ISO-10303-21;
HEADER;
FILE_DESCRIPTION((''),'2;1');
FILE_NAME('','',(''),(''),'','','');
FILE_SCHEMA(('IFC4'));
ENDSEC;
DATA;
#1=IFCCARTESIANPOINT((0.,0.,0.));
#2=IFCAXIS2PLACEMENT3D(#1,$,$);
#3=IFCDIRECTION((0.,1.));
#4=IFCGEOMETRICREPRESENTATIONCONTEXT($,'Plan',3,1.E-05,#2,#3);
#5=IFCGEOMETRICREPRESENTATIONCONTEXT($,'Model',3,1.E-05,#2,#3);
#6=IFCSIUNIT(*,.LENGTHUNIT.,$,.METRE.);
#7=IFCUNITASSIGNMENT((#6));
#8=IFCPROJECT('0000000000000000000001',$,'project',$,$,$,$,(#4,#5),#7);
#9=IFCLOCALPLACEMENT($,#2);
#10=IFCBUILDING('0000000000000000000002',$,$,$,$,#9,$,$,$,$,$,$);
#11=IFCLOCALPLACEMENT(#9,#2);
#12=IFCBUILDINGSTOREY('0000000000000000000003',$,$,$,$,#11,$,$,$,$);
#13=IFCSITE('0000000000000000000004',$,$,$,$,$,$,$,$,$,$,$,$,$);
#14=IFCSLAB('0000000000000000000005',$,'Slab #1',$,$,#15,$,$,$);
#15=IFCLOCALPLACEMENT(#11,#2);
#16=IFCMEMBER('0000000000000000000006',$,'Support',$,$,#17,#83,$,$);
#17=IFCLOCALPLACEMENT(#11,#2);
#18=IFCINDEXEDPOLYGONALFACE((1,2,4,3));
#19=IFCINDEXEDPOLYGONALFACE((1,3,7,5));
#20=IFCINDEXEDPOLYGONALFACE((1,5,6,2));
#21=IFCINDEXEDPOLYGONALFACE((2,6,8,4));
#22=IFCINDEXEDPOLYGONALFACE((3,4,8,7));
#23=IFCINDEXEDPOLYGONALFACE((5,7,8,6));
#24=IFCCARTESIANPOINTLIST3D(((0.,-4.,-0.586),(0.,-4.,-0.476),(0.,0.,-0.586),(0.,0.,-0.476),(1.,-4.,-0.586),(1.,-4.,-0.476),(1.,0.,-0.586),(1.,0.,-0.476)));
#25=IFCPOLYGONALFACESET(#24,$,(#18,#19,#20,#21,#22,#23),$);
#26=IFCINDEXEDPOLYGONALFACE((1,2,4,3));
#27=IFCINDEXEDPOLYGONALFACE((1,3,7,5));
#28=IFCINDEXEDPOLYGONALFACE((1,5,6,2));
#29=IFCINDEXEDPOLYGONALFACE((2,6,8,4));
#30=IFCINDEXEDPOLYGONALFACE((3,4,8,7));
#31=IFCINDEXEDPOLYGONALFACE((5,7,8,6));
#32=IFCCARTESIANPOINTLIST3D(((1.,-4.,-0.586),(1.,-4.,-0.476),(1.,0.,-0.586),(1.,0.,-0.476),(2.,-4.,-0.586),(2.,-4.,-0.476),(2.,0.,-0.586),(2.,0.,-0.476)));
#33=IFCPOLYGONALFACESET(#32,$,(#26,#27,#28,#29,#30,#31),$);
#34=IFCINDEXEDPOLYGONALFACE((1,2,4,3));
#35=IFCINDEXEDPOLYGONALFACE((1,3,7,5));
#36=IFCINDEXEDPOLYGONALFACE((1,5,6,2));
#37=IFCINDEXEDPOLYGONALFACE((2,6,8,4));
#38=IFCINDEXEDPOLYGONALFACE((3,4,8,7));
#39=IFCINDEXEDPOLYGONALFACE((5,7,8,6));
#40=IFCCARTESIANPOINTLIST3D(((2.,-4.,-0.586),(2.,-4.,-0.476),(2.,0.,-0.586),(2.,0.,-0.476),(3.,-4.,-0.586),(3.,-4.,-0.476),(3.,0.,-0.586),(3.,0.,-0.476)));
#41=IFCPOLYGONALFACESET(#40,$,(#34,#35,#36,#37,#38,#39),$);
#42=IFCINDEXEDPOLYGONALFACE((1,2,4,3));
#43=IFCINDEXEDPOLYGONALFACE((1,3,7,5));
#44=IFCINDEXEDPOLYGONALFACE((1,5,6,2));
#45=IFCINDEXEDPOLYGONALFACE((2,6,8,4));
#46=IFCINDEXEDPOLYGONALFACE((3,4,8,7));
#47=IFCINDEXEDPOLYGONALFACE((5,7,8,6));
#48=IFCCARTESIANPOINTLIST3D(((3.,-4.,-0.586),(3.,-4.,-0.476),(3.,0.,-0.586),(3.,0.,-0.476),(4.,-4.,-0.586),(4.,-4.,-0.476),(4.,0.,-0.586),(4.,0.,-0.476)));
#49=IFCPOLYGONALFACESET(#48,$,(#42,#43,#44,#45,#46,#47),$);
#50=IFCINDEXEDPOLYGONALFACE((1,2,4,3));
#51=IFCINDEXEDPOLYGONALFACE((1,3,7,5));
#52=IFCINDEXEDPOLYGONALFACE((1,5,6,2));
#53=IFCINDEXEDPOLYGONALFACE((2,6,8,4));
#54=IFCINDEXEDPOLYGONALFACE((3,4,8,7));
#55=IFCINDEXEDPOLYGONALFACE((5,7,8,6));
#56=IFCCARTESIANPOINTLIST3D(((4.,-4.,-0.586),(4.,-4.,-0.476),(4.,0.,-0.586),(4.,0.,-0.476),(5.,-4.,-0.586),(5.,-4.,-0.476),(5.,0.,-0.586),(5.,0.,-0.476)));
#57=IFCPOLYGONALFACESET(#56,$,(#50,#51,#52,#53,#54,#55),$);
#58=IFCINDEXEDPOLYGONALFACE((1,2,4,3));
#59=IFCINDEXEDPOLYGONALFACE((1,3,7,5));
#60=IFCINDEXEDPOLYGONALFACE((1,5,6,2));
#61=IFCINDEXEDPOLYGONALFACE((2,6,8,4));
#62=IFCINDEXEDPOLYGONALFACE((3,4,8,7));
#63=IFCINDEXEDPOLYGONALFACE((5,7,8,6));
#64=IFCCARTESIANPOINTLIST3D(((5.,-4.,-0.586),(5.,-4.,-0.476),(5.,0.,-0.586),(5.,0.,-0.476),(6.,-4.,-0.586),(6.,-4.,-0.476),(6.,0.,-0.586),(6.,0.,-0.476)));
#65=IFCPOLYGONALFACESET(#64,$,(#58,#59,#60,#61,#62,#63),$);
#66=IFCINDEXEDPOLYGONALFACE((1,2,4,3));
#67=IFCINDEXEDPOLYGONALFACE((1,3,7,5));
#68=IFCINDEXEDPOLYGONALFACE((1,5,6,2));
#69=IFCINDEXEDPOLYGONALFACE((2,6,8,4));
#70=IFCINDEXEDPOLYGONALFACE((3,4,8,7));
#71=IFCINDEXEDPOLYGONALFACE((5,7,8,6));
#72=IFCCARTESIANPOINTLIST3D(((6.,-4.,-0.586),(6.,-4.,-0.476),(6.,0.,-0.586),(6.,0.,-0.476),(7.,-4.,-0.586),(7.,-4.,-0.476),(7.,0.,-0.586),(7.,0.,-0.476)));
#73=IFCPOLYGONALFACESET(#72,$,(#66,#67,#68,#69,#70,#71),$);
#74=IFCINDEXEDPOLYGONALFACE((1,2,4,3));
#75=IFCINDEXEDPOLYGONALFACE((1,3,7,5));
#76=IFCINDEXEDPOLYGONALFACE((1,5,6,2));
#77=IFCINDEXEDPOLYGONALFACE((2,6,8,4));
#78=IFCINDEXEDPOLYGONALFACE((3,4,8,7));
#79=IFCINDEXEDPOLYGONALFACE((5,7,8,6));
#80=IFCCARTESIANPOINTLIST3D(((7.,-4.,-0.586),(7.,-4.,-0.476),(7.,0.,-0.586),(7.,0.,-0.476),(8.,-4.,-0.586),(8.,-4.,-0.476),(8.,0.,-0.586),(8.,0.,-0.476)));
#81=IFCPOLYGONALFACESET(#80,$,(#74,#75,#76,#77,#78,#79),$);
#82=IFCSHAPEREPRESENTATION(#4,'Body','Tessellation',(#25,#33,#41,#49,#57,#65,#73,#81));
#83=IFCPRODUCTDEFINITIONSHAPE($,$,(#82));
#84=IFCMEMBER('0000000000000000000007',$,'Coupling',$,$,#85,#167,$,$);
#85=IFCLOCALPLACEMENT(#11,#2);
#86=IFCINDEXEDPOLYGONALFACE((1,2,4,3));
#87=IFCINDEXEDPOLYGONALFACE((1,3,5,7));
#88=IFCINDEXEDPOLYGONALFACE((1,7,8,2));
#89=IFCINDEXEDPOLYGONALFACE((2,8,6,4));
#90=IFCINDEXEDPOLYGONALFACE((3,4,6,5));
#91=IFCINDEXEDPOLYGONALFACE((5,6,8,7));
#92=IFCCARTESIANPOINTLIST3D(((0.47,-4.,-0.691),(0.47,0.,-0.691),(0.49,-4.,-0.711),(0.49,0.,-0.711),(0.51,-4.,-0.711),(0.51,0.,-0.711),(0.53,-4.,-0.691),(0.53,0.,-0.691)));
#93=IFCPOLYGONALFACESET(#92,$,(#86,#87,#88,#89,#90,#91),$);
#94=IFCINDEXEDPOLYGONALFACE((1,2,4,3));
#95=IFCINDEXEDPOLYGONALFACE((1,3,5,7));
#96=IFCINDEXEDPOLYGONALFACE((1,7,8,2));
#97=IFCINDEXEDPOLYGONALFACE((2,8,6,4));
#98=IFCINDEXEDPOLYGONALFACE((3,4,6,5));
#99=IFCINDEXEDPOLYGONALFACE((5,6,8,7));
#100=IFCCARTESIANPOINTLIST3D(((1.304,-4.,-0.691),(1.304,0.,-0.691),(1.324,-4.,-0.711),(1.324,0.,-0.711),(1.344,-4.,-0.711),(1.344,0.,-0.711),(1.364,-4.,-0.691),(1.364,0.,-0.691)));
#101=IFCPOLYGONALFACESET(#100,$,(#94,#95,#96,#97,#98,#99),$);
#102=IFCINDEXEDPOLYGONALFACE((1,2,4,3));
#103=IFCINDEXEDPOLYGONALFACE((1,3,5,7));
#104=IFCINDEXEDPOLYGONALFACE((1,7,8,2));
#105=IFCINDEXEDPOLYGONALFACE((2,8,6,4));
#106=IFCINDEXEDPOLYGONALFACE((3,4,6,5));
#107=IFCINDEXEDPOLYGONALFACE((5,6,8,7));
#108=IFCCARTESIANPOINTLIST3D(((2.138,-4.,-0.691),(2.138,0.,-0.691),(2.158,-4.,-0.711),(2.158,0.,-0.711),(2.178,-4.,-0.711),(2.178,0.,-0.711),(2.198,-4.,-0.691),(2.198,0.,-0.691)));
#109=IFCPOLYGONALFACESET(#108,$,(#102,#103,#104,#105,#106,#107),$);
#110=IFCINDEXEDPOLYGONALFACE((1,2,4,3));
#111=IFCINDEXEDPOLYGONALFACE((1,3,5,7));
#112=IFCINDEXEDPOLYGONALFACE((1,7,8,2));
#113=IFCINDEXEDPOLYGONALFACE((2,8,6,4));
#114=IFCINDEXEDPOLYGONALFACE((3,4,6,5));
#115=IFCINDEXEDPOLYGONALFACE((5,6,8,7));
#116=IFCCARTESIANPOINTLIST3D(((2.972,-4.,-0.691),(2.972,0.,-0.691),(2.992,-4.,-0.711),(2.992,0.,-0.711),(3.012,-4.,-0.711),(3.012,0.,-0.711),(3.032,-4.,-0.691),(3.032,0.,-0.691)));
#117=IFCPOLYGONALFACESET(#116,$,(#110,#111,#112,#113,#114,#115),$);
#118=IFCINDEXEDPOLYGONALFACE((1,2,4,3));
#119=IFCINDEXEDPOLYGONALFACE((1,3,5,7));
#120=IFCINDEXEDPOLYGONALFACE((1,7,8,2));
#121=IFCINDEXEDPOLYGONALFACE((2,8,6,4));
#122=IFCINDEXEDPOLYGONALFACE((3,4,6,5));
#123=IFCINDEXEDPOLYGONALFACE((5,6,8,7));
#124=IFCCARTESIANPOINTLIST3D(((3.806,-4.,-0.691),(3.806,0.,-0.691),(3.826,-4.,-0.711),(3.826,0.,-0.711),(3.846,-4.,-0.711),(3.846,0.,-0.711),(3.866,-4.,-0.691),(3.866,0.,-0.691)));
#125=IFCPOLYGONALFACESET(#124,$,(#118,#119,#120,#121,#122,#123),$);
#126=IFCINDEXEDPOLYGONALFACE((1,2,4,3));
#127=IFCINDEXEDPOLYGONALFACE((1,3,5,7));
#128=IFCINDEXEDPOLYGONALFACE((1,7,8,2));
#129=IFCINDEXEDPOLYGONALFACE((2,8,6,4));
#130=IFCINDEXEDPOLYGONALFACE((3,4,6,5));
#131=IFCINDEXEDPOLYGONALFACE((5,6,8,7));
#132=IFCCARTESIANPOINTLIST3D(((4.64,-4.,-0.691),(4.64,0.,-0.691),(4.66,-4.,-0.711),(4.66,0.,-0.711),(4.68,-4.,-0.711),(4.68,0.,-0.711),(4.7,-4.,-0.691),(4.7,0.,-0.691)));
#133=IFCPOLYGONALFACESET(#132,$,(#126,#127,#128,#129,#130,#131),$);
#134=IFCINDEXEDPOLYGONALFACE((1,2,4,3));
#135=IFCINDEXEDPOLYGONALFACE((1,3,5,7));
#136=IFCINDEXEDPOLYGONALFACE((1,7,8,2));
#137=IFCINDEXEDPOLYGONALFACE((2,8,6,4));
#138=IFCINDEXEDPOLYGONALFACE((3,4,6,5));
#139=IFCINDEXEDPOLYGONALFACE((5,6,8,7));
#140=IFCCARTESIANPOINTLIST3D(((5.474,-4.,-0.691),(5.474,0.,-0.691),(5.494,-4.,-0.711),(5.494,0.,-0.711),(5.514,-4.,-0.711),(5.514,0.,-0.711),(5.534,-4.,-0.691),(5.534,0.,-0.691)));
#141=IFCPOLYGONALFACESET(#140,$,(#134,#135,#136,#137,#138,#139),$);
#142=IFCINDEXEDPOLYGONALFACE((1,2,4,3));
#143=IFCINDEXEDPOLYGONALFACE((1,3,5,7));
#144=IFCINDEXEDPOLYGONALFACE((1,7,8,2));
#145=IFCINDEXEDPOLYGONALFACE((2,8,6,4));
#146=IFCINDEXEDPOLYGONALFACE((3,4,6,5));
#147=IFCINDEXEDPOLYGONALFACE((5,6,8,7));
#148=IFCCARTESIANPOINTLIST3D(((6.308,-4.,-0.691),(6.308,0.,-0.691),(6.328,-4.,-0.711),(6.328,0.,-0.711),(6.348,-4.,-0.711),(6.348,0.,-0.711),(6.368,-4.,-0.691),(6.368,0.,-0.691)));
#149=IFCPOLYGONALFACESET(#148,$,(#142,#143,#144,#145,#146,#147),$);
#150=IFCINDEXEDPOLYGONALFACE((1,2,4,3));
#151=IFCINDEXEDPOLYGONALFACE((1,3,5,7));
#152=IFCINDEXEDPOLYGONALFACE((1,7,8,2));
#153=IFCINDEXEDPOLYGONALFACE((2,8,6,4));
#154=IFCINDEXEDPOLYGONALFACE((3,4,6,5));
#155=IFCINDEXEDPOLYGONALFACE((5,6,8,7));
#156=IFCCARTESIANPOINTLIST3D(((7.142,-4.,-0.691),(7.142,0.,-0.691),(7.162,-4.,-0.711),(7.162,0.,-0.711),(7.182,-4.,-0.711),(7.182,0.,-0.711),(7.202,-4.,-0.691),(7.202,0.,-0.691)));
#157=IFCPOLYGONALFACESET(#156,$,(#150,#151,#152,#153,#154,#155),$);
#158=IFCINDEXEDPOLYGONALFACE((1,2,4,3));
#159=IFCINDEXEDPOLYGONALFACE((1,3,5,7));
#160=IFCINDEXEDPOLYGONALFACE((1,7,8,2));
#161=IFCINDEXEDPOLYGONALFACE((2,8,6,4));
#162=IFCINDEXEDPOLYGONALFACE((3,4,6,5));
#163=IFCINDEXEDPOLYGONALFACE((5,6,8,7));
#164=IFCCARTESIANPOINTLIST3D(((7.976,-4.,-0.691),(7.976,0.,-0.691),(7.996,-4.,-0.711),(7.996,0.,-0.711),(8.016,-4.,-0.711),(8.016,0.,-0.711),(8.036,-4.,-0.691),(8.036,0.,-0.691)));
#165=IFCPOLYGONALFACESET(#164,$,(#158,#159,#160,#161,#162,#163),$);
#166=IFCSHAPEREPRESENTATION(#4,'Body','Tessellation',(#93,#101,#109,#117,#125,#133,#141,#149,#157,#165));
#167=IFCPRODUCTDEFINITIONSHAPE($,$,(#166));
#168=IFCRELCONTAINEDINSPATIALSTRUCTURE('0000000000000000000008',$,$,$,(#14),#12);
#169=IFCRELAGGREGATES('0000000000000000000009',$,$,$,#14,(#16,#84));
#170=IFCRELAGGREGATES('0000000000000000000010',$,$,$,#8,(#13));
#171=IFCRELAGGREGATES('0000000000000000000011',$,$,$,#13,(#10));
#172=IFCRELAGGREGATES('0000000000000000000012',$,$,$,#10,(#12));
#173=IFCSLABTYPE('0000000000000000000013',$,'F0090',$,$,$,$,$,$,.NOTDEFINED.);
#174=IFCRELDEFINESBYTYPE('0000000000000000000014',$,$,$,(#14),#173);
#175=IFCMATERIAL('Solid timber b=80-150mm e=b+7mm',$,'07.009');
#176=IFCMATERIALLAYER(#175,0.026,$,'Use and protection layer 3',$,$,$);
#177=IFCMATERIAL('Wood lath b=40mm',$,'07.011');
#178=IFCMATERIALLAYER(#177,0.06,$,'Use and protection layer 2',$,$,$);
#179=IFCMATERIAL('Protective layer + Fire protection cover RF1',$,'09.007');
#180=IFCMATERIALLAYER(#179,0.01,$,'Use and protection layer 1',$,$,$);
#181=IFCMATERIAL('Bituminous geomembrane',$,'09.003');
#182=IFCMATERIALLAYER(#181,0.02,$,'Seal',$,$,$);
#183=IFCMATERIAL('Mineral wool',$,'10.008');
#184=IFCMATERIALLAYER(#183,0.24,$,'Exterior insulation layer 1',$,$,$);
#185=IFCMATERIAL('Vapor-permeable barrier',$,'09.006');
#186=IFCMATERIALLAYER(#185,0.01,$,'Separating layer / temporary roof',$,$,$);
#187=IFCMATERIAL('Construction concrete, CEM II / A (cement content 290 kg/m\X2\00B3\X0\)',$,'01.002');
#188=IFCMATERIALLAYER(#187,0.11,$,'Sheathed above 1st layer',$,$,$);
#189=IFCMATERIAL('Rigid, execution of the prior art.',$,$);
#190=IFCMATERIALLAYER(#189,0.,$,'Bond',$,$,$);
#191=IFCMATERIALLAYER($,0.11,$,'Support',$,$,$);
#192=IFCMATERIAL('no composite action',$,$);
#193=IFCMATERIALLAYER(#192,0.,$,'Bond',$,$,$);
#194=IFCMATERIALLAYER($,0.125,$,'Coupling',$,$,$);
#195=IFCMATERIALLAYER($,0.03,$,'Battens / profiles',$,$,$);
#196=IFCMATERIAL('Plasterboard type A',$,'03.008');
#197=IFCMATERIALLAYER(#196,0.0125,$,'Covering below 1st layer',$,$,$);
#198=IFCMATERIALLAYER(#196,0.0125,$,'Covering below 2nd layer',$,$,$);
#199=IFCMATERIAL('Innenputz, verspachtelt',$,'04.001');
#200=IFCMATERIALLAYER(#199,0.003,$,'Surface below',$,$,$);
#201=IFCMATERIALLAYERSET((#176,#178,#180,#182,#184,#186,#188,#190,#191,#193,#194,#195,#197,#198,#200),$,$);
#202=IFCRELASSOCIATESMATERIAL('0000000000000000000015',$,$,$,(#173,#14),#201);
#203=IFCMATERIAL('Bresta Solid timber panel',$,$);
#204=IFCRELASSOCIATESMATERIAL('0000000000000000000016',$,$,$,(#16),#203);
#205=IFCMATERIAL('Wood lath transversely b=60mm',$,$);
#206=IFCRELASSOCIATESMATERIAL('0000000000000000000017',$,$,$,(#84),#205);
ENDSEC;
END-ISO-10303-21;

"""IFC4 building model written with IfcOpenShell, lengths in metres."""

from ifc_helpers import new_model, si_unit, direction, frame, frame_2d, origin, place, context, project, spatial, polyline, rectangle, outline, extrude, material, layer, layer_set, type_object, element, aggregate, save


model = new_model("IFC4")

# Units and contexts
plan_context = context("Plan", 3, precision=1e-05, world=origin(), true_north=direction((0.0, 1.0)))
model_context = context("Model", 3, precision=1e-05, world=origin(), true_north=direction((0.0, 1.0)))
ifc_project = project(units=[si_unit("LENGTHUNIT", "METRE")], contexts=[plan_context, model_context])

# Site, building, storey
site = spatial("IfcSite", under=ifc_project)
building_placement = place(None, origin())
building = spatial("IfcBuilding", under=site, at=building_placement)
storey_placement = place(building_placement, origin())
storey = spatial("IfcBuildingStorey", under=building, at=storey_placement)

# Slab, members
ifc_material_1 = material(Name="Solid timber b=80-150mm e=b+7mm", Category="07.009")
ifc_layer_1 = layer(ifc_material_1, 0.026, Name="Use and protection layer 3")
ifc_material_2 = material(Name="Wood lath b=40mm", Category="07.011")
ifc_layer_2 = layer(ifc_material_2, 0.06, Name="Use and protection layer 2")
ifc_material_3 = material(Name="Protective layer + Fire protection cover RF1", Category="09.007")
ifc_layer_3 = layer(ifc_material_3, 0.01, Name="Use and protection layer 1")
ifc_material_4 = material(Name="Bituminous geomembrane", Category="09.003")
ifc_layer_4 = layer(ifc_material_4, 0.02, Name="Seal")
ifc_material_5 = material(Name="Mineral wool", Category="10.008")
ifc_layer_5 = layer(ifc_material_5, 0.24, Name="Exterior insulation layer 1")
ifc_material_6 = material(Name="Vapor-permeable barrier", Category="09.006")
ifc_layer_6 = layer(ifc_material_6, 0.01, Name="Separating layer / temporary roof")
ifc_material_7 = material(Name="Construction concrete, CEM II / A (cement content 290 kg/m³)", Category="01.002")
ifc_layer_7 = layer(ifc_material_7, 0.11, Name="Sheathed above 1st layer")
ifc_material_8 = material(Name="Rigid, execution of the prior art.")
ifc_layer_8 = layer(ifc_material_8, 0.0, Name="Bond")
ifc_layer_9 = layer(None, 0.11, Name="Support")
ifc_material_9 = material(Name="no composite action")
ifc_layer_10 = layer(ifc_material_9, 0.0, Name="Bond")
ifc_layer_11 = layer(None, 0.125, Name="Coupling")
ifc_layer_12 = layer(None, 0.03, Name="Battens / profiles")
ifc_material_10 = material(Name="Plasterboard type A", Category="03.008")
ifc_layer_13 = layer(ifc_material_10, 0.0125, Name="Covering below 1st layer")
ifc_layer_14 = layer(ifc_material_10, 0.0125, Name="Covering below 2nd layer")
ifc_material_11 = material(Name="Innenputz, verspachtelt", Category="04.001")
ifc_layer_15 = layer(ifc_material_11, 0.003, Name="Surface below")
ifc_layer_set = layer_set([ifc_layer_1, ifc_layer_2, ifc_layer_3, ifc_layer_4, ifc_layer_5, ifc_layer_6, ifc_layer_7, ifc_layer_8, ifc_layer_9, ifc_layer_10, ifc_layer_11, ifc_layer_12, ifc_layer_13, ifc_layer_14, ifc_layer_15])
slab_type = type_object("IfcSlabType", Name="F0090", PredefinedType="NOTDEFINED", material=ifc_layer_set)
slab_placement = place(None, frame((0.0, 0.0, 0.0), z_axis=(0.0, 0.0, -1.0), x_axis=(1.0, 0.0, 0.0)))
slab = element("IfcSlab", 1, at=slab_placement, inside=storey, type_object=slab_type, material=ifc_layer_set, Name="Slab #1")
ifc_material_12 = material(Name="Bresta Solid timber panel")
member_1_placement = place(slab_placement, origin())
member_1 = element("IfcMember", 2, at=member_1_placement, material=ifc_material_12, Name="Support", context=plan_context, shape_type="SweptSolid", body=[
    extrude(rectangle(XDim=1.0, YDim=0.11, at=frame_2d((0.5, 0.055), x_axis=(1.0, 0.0))), frame((0.0, 4.0, 0.476), z_axis=(0.0, -1.0, 0.0), x_axis=(1.0, 0.0, 0.0)), (0.0, 0.0, 1.0), 4.0),
    extrude(rectangle(XDim=1.0, YDim=0.11, at=frame_2d((0.5, 0.055), x_axis=(1.0, 0.0))), frame((1.0, 4.0, 0.476), z_axis=(0.0, -1.0, 0.0), x_axis=(1.0, 0.0, 0.0)), (0.0, 0.0, 1.0), 4.0),
    extrude(rectangle(XDim=1.0, YDim=0.11, at=frame_2d((0.5, 0.055), x_axis=(1.0, 0.0))), frame((2.0, 4.0, 0.476), z_axis=(0.0, -1.0, 0.0), x_axis=(1.0, 0.0, 0.0)), (0.0, 0.0, 1.0), 4.0),
    extrude(rectangle(XDim=1.0, YDim=0.11, at=frame_2d((0.5, 0.055), x_axis=(1.0, 0.0))), frame((3.0, 4.0, 0.476), z_axis=(0.0, -1.0, 0.0), x_axis=(1.0, 0.0, 0.0)), (0.0, 0.0, 1.0), 4.0),
    extrude(rectangle(XDim=1.0, YDim=0.11, at=frame_2d((0.5, 0.055), x_axis=(1.0, 0.0))), frame((4.0, 4.0, 0.476), z_axis=(0.0, -1.0, 0.0), x_axis=(1.0, 0.0, 0.0)), (0.0, 0.0, 1.0), 4.0),
    extrude(rectangle(XDim=1.0, YDim=0.11, at=frame_2d((0.5, 0.055), x_axis=(1.0, 0.0))), frame((5.0, 4.0, 0.476), z_axis=(0.0, -1.0, 0.0), x_axis=(1.0, 0.0, 0.0)), (0.0, 0.0, 1.0), 4.0),
    extrude(rectangle(XDim=1.0, YDim=0.11, at=frame_2d((0.5, 0.055), x_axis=(1.0, 0.0))), frame((6.0, 4.0, 0.476), z_axis=(0.0, -1.0, 0.0), x_axis=(1.0, 0.0, 0.0)), (0.0, 0.0, 1.0), 4.0),
    extrude(rectangle(XDim=1.0, YDim=0.11, at=frame_2d((0.5, 0.055), x_axis=(1.0, 0.0))), frame((7.0, 4.0, 0.476), z_axis=(0.0, -1.0, 0.0), x_axis=(1.0, 0.0, 0.0)), (0.0, 0.0, 1.0), 4.0),
])
ifc_material_13 = material(Name="Wood lath transversely b=60mm")
member_2_placement = place(slab_placement, origin())
member_2 = element("IfcMember", 3, at=member_2_placement, material=ifc_material_13, Name="Coupling", context=plan_context, shape_type="SweptSolid", body=[
    extrude(outline(polyline([(0.0, 0.0), (0.06, 0.0), (0.04, 0.02), (0.02, 0.02), (0.0, 0.0)])), frame((0.47, 4.0, 0.691), z_axis=(0.0, -1.0, 0.0), x_axis=(1.0, 0.0, 0.0)), (0.0, 0.0, 1.0), 4.0),
    extrude(outline(polyline([(0.0, 0.0), (0.06, 0.0), (0.04, 0.02), (0.02, 0.02), (0.0, 0.0)])), frame((1.304, 4.0, 0.691), z_axis=(0.0, -1.0, 0.0), x_axis=(1.0, 0.0, 0.0)), (0.0, 0.0, 1.0), 4.0),
    extrude(outline(polyline([(0.0, 0.0), (0.06, 0.0), (0.04, 0.02), (0.02, 0.02), (0.0, 0.0)])), frame((2.138, 4.0, 0.691), z_axis=(0.0, -1.0, 0.0), x_axis=(1.0, 0.0, 0.0)), (0.0, 0.0, 1.0), 4.0),
    extrude(outline(polyline([(0.0, 0.0), (0.06, 0.0), (0.04, 0.02), (0.02, 0.02), (0.0, 0.0)])), frame((2.972, 4.0, 0.691), z_axis=(0.0, -1.0, 0.0), x_axis=(1.0, 0.0, 0.0)), (0.0, 0.0, 1.0), 4.0),
    extrude(outline(polyline([(0.0, 0.0), (0.06, 0.0), (0.04, 0.02), (0.02, 0.02), (0.0, 0.0)])), frame((3.806, 4.0, 0.691), z_axis=(0.0, -1.0, 0.0), x_axis=(1.0, 0.0, 0.0)), (0.0, 0.0, 1.0), 4.0),
    extrude(outline(polyline([(0.0, 0.0), (0.06, 0.0), (0.04, 0.02), (0.02, 0.02), (0.0, 0.0)])), frame((4.64, 4.0, 0.691), z_axis=(0.0, -1.0, 0.0), x_axis=(1.0, 0.0, 0.0)), (0.0, 0.0, 1.0), 4.0),
    extrude(outline(polyline([(0.0, 0.0), (0.06, 0.0), (0.04, 0.02), (0.02, 0.02), (0.0, 0.0)])), frame((5.474, 4.0, 0.691), z_axis=(0.0, -1.0, 0.0), x_axis=(1.0, 0.0, 0.0)), (0.0, 0.0, 1.0), 4.0),
    extrude(outline(polyline([(0.0, 0.0), (0.06, 0.0), (0.04, 0.02), (0.02, 0.02), (0.0, 0.0)])), frame((6.308, 4.0, 0.691), z_axis=(0.0, -1.0, 0.0), x_axis=(1.0, 0.0, 0.0)), (0.0, 0.0, 1.0), 4.0),
    extrude(outline(polyline([(0.0, 0.0), (0.06, 0.0), (0.04, 0.02), (0.02, 0.02), (0.0, 0.0)])), frame((7.142, 4.0, 0.691), z_axis=(0.0, -1.0, 0.0), x_axis=(1.0, 0.0, 0.0)), (0.0, 0.0, 1.0), 4.0),
    extrude(outline(polyline([(0.0, 0.0), (0.06, 0.0), (0.04, 0.02), (0.02, 0.02), (0.0, 0.0)])), frame((7.976, 4.0, 0.691), z_axis=(0.0, -1.0, 0.0), x_axis=(1.0, 0.0, 0.0)), (0.0, 0.0, 1.0), 4.0),
])
aggregate(slab, [member_1, member_2])

save(model, "model.ifc")
